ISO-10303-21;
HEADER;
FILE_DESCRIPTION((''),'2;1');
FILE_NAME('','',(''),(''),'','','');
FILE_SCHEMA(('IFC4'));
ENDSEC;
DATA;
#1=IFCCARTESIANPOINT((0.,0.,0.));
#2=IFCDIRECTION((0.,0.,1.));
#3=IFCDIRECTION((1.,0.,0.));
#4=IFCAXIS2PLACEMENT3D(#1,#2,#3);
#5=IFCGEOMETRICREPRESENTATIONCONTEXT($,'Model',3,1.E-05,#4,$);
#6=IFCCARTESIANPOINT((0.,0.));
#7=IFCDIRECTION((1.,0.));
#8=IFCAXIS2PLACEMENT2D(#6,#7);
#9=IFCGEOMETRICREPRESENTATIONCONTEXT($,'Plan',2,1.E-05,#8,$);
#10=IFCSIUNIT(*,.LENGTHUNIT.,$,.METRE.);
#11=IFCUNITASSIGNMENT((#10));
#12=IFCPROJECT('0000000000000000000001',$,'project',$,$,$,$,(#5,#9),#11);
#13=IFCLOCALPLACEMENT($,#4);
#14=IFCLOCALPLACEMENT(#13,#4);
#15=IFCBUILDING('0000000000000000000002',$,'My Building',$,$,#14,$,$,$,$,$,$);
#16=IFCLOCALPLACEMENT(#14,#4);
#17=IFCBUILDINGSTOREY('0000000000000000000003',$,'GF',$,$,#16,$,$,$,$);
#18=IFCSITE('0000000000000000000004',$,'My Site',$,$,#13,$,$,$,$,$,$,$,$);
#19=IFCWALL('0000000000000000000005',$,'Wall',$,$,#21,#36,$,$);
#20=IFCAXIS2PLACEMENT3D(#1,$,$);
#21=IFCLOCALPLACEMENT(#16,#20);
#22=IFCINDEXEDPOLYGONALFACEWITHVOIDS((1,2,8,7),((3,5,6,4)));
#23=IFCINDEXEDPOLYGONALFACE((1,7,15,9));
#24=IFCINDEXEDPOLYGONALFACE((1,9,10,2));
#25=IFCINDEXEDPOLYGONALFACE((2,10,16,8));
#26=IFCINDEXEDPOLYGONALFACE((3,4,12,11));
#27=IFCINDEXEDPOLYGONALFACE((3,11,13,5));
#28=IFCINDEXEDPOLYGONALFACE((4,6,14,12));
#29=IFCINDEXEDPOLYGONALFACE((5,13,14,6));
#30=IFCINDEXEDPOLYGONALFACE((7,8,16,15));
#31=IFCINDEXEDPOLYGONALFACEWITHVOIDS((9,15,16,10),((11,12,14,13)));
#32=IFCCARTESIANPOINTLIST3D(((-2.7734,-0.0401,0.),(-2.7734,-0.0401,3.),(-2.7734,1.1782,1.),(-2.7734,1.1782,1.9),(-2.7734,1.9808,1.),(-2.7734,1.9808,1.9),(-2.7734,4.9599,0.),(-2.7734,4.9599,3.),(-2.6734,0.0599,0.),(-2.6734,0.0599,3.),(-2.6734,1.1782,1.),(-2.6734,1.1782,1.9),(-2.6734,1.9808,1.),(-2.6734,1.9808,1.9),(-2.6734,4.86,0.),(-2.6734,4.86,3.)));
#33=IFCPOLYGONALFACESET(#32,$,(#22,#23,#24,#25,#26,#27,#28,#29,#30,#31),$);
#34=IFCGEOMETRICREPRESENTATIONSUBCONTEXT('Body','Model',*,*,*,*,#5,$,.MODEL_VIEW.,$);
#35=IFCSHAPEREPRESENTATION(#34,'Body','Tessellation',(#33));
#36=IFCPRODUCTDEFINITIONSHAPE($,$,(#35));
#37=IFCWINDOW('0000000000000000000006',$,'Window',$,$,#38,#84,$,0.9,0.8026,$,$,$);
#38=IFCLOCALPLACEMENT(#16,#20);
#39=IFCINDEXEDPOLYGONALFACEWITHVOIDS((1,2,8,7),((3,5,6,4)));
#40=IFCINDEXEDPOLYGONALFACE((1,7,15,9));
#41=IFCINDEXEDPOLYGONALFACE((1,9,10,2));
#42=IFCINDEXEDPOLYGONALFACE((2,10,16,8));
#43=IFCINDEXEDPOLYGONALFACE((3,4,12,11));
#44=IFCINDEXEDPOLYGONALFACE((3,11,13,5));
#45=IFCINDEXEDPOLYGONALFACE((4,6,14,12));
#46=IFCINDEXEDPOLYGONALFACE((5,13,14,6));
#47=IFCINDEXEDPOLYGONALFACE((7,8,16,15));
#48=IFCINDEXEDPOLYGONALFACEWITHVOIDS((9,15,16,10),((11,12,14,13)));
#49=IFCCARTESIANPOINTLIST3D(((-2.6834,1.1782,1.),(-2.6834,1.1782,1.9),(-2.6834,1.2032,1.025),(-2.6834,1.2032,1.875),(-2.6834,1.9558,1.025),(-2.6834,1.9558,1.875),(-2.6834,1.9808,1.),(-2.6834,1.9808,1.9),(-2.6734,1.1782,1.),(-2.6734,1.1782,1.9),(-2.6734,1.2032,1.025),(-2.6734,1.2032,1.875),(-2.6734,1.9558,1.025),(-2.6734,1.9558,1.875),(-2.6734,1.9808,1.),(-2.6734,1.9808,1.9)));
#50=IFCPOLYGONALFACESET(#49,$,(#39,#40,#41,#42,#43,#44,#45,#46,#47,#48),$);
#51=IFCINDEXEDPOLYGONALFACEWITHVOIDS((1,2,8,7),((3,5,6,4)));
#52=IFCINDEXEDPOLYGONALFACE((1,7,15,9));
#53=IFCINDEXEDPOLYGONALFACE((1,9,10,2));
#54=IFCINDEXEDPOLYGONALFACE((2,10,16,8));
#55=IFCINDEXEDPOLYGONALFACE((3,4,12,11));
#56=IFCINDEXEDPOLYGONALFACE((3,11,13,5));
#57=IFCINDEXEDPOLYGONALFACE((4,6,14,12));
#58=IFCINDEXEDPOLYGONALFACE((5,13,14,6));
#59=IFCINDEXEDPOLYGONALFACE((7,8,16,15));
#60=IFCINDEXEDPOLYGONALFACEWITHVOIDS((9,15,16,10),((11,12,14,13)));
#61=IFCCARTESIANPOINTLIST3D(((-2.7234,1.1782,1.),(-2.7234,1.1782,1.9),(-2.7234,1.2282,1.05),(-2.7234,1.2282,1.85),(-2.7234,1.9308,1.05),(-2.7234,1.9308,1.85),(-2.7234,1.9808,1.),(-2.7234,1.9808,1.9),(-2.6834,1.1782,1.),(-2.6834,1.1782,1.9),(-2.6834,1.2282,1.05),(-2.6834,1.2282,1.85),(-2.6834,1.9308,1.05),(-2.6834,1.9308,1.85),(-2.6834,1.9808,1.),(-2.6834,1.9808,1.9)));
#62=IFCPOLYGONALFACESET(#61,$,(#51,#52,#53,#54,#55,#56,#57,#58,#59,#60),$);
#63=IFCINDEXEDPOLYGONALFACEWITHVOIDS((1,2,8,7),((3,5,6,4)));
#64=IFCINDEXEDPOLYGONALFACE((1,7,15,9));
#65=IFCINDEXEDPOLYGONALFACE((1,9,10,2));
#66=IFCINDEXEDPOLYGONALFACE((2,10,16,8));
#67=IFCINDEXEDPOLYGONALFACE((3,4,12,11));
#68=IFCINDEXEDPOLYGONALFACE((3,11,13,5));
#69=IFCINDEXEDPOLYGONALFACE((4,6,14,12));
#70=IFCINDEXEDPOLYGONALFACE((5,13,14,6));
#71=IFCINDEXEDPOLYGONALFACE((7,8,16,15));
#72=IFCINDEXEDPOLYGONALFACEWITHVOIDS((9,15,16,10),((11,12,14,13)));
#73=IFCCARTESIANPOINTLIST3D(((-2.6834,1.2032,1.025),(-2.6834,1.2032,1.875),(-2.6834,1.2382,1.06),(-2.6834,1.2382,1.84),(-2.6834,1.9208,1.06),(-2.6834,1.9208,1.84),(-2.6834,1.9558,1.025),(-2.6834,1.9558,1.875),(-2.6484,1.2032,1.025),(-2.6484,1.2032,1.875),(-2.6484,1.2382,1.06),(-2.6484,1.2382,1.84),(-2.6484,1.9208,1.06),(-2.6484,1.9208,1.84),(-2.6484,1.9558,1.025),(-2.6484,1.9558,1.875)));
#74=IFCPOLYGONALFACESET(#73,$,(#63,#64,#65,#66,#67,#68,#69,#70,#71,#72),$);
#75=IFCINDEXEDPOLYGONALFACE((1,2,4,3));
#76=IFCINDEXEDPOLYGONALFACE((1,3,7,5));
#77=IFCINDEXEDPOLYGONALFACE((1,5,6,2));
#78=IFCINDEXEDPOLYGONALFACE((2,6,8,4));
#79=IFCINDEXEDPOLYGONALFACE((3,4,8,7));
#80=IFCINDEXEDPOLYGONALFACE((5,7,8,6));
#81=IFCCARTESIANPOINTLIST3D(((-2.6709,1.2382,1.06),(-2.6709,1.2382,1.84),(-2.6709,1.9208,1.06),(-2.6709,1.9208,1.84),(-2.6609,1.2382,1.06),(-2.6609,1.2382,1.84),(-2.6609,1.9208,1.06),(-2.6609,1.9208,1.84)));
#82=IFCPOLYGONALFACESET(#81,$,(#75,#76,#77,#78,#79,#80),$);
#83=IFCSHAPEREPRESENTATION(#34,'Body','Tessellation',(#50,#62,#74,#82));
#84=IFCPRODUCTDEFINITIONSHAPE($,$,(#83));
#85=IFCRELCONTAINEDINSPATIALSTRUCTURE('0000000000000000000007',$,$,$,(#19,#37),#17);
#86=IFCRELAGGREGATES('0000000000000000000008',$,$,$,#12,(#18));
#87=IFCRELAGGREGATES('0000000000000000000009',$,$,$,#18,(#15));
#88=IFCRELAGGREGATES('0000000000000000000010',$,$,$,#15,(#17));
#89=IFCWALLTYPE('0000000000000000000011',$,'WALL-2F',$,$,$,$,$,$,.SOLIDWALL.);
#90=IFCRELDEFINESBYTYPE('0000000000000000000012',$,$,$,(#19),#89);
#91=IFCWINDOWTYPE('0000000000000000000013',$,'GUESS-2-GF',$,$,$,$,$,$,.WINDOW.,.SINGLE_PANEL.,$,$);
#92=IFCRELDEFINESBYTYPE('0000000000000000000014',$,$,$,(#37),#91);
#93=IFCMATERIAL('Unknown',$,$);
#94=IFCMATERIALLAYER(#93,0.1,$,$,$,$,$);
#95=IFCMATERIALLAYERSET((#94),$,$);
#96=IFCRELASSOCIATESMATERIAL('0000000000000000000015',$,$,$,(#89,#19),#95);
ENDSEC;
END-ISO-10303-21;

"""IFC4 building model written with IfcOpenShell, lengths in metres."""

from ifc_helpers import new_model, entity, si_unit, frame, origin_with_axes, origin_2d_with_axis, place, context, subcontext, project, spatial, line, indexed_curve, outline, extrude, shape, source, transform, mapped, material, layer, layer_set, layer_usage, type_object, type_shapes, element, fill, save


model = new_model("IFC4")

# Units and contexts
model_context = context("Model", 3, precision=1e-05, world=origin_with_axes())
plan_context = context("Plan", 2, precision=1e-05, world=origin_2d_with_axis())
body_context_1 = subcontext(model_context, "Body", "Model", "MODEL_VIEW")
body_context_2 = subcontext(plan_context, "Body", "Plan", "PLAN_VIEW")
ifc_project = project(units=[si_unit("LENGTHUNIT", "METRE")], contexts=[model_context, plan_context])

# Site, building, storey
site_placement = place(None, origin_with_axes())
site = spatial("IfcSite", under=ifc_project, at=site_placement, Name="My Site")
building_placement = place(site_placement, origin_with_axes())
building = spatial("IfcBuilding", under=site, at=building_placement, Name="My Building")
storey_placement = place(building_placement, origin_with_axes())
storey = spatial("IfcBuildingStorey", under=building, at=storey_placement, Name="GF")

# Shared definitions
ifc_material_1 = material(Name="Unknown")

# Shared definitions
ifc_layer_1 = layer(ifc_material_1, 0.1)
ifc_layer_set_1 = layer_set([ifc_layer_1])
wall_type_1 = type_object("IfcWallType", Name="WALL-2F", PredefinedType="SOLIDWALL", material=ifc_layer_set_1)

# Wall, opening, window
ifc_layer_usage_1 = layer_usage(ifc_layer_set_1, "AXIS2", "POSITIVE", 0.0)
wall_1_placement = place(storey_placement, frame((-2.7734, 4.8599, 0.0), z_axis=(0.0, 0.0, 1.0), x_axis=(0.0, -1.0, 0.0)))
wall_1 = element("IfcWall", 1, at=wall_1_placement, inside=storey, type_object=wall_type_1, material=ifc_layer_usage_1, Name="Wall", context=body_context_1, shape_type="SweptSolid", body=[
    extrude(outline(indexed_curve([(-0.1, 0.0), (-0.0001, 0.1), (4.8, 0.1), (4.9, 0.0)], segments=[line(1, 2, 3, 4, 1)])), origin_with_axes(), (0.0, 0.0, 1.0), 3.0),
])
shared_shape_1 = source(origin_with_axes(), body_context_1, "Body", "SweptSolid", [
    extrude(outline(indexed_curve([(0.0, 0.0), (0.8026, 0.0), (0.8026, 0.9), (0.0, 0.9)], segments=[line(1, 2, 3, 4, 1)])), frame((0.0, -0.6, 0.0), z_axis=(0.0, -1.0, 0.0), x_axis=(1.0, 0.0, 0.0)), (0.0, 0.0, -1.0), 1.2),
])
opening_1_placement = place(wall_1_placement, frame((2.8791, 0.0, 1.0), z_axis=(0.0, 0.0, 1.0), x_axis=(1.0, 0.0, 0.0)))
opening_1 = element("IfcOpeningElement", 2, at=opening_1_placement, cuts=wall_1, PredefinedType="OPENING", context=body_context_1, shape_type="MappedRepresentation", body=[
    mapped(shared_shape_1, transform((0.0, 0.0, 0.0), x_axis=(1.0, 0.0, 0.0), y_axis=(0.0, 1.0, 0.0), z_axis=(0.0, 0.0, 1.0), scale=1.0)),
])
window_type_1 = type_object("IfcWindowType", Name="GUESS-2-GF", PartitioningType="SINGLE_PANEL", PredefinedType="WINDOW")
shared_shape_2 = source(origin_with_axes(), body_context_1, "Body", "SweptSolid", [
    extrude(outline(indexed_curve([(0.0, 0.0), (0.8026, 0.0), (0.8026, 0.9), (0.0, 0.9)], segments=[line(1, 2, 3, 4, 1)]), holes=[indexed_curve([(0.025, 0.025), (0.7776, 0.025), (0.7776, 0.875), (0.025, 0.875)], segments=[line(1, 2, 3, 4, 1)])]), frame((0.0, 0.09, 0.0), z_axis=(0.0, -1.0, 0.0), x_axis=(1.0, 0.0, 0.0)), (0.0, 0.0, -1.0), 0.01),
    extrude(outline(indexed_curve([(0.0, 0.0), (0.8026, 0.0), (0.8026, 0.9), (0.0, 0.9)], segments=[line(1, 2, 3, 4, 1)]), holes=[indexed_curve([(0.05, 0.05), (0.7526, 0.05), (0.7526, 0.85), (0.05, 0.85)], segments=[line(1, 2, 3, 4, 1)])]), frame((0.0, 0.05, 0.0), z_axis=(0.0, -1.0, 0.0), x_axis=(1.0, 0.0, 0.0)), (0.0, 0.0, -1.0), 0.04),
    extrude(outline(indexed_curve([(0.0, 0.0), (0.7526, 0.0), (0.7526, 0.85), (0.0, 0.85)], segments=[line(1, 2, 3, 4, 1)]), holes=[indexed_curve([(0.035, 0.035), (0.7176, 0.035), (0.7176, 0.815), (0.035, 0.815)], segments=[line(1, 2, 3, 4, 1)])]), frame((0.025, 0.09, 0.025), z_axis=(0.0, -1.0, 0.0), x_axis=(1.0, 0.0, 0.0)), (0.0, 0.0, -1.0), 0.035),
    extrude(outline(indexed_curve([(0.035, 0.035), (0.7176, 0.035), (0.7176, 0.815), (0.035, 0.815)], segments=[line(1, 2, 3, 4, 1)])), frame((0.025, 0.1025, 0.025), z_axis=(0.0, -1.0, 0.0), x_axis=(1.0, 0.0, 0.0)), (0.0, 0.0, -1.0), 0.01),
])
shared_shape_3 = source(origin_with_axes(), body_context_2, "Body", "Curve2D", [
    entity("IfcIndexedPolyCurve", entity("IfcCartesianPointList2D", [[0.05, 0.05], [0.7526, 0.05]])),
    entity("IfcIndexedPolyCurve", entity("IfcCartesianPointList2D", [[0.0, 0.1], [0.025, 0.1], [0.025, 0.09], [0.05, 0.09], [0.05, 0.05], [0.0, 0.05]]), [entity("IfcLineIndex", [1, 2, 3, 4, 5, 6, 1])]),
    entity("IfcIndexedPolyCurve", entity("IfcCartesianPointList2D", [[0.8026, 0.1], [0.7776, 0.1], [0.7776, 0.09], [0.7526, 0.09], [0.7526, 0.05], [0.8026, 0.05]]), [entity("IfcLineIndex", [1, 2, 3, 4, 5, 6, 1])]),
    entity("IfcIndexedPolyCurve", entity("IfcCartesianPointList2D", [[0.025, 0.09], [0.06, 0.09], [0.06, 0.125], [0.025, 0.125]]), [entity("IfcLineIndex", [1, 2, 3, 4, 1])]),
    entity("IfcIndexedPolyCurve", entity("IfcCartesianPointList2D", [[0.7776, 0.09], [0.7426, 0.09], [0.7426, 0.125], [0.7776, 0.125]]), [entity("IfcLineIndex", [1, 2, 3, 4, 1])]),
    entity("IfcIndexedPolyCurve", entity("IfcCartesianPointList2D", [[0.06, 0.09], [0.7426, 0.09]])),
    entity("IfcIndexedPolyCurve", entity("IfcCartesianPointList2D", [[0.06, 0.125], [0.7426, 0.125]])),
    entity("IfcIndexedPolyCurve", entity("IfcCartesianPointList2D", [[0.06, 0.1075], [0.7426, 0.1075]])),
])
type_shapes(window_type_1, [shared_shape_2, shared_shape_3])
window_1_placement = place(opening_1_placement, frame((0.0, 0.0, 0.0), z_axis=(0.0, 0.0, 1.0), x_axis=(1.0, 0.0, 0.0)))
window_1 = element("IfcWindow", 3, at=window_1_placement, inside=storey, type_object=window_type_1, Name="Window", OverallHeight=0.9, OverallWidth=0.8026, shapes=[
    shape(body_context_1, "Body", "MappedRepresentation", [mapped(shared_shape_2, transform((0.0, 0.0, 0.0), x_axis=(1.0, 0.0, 0.0), y_axis=(0.0, 1.0, 0.0), z_axis=(0.0, 0.0, 1.0), scale=1.0))]),
    shape(body_context_2, "Body", "MappedRepresentation", [mapped(shared_shape_3, transform((0.0, 0.0, 0.0), x_axis=(1.0, 0.0, 0.0), y_axis=(0.0, 1.0, 0.0), z_axis=(0.0, 0.0, 1.0), scale=1.0))]),
])
fill(opening_1, window_1)

save(model, "model.ifc")
